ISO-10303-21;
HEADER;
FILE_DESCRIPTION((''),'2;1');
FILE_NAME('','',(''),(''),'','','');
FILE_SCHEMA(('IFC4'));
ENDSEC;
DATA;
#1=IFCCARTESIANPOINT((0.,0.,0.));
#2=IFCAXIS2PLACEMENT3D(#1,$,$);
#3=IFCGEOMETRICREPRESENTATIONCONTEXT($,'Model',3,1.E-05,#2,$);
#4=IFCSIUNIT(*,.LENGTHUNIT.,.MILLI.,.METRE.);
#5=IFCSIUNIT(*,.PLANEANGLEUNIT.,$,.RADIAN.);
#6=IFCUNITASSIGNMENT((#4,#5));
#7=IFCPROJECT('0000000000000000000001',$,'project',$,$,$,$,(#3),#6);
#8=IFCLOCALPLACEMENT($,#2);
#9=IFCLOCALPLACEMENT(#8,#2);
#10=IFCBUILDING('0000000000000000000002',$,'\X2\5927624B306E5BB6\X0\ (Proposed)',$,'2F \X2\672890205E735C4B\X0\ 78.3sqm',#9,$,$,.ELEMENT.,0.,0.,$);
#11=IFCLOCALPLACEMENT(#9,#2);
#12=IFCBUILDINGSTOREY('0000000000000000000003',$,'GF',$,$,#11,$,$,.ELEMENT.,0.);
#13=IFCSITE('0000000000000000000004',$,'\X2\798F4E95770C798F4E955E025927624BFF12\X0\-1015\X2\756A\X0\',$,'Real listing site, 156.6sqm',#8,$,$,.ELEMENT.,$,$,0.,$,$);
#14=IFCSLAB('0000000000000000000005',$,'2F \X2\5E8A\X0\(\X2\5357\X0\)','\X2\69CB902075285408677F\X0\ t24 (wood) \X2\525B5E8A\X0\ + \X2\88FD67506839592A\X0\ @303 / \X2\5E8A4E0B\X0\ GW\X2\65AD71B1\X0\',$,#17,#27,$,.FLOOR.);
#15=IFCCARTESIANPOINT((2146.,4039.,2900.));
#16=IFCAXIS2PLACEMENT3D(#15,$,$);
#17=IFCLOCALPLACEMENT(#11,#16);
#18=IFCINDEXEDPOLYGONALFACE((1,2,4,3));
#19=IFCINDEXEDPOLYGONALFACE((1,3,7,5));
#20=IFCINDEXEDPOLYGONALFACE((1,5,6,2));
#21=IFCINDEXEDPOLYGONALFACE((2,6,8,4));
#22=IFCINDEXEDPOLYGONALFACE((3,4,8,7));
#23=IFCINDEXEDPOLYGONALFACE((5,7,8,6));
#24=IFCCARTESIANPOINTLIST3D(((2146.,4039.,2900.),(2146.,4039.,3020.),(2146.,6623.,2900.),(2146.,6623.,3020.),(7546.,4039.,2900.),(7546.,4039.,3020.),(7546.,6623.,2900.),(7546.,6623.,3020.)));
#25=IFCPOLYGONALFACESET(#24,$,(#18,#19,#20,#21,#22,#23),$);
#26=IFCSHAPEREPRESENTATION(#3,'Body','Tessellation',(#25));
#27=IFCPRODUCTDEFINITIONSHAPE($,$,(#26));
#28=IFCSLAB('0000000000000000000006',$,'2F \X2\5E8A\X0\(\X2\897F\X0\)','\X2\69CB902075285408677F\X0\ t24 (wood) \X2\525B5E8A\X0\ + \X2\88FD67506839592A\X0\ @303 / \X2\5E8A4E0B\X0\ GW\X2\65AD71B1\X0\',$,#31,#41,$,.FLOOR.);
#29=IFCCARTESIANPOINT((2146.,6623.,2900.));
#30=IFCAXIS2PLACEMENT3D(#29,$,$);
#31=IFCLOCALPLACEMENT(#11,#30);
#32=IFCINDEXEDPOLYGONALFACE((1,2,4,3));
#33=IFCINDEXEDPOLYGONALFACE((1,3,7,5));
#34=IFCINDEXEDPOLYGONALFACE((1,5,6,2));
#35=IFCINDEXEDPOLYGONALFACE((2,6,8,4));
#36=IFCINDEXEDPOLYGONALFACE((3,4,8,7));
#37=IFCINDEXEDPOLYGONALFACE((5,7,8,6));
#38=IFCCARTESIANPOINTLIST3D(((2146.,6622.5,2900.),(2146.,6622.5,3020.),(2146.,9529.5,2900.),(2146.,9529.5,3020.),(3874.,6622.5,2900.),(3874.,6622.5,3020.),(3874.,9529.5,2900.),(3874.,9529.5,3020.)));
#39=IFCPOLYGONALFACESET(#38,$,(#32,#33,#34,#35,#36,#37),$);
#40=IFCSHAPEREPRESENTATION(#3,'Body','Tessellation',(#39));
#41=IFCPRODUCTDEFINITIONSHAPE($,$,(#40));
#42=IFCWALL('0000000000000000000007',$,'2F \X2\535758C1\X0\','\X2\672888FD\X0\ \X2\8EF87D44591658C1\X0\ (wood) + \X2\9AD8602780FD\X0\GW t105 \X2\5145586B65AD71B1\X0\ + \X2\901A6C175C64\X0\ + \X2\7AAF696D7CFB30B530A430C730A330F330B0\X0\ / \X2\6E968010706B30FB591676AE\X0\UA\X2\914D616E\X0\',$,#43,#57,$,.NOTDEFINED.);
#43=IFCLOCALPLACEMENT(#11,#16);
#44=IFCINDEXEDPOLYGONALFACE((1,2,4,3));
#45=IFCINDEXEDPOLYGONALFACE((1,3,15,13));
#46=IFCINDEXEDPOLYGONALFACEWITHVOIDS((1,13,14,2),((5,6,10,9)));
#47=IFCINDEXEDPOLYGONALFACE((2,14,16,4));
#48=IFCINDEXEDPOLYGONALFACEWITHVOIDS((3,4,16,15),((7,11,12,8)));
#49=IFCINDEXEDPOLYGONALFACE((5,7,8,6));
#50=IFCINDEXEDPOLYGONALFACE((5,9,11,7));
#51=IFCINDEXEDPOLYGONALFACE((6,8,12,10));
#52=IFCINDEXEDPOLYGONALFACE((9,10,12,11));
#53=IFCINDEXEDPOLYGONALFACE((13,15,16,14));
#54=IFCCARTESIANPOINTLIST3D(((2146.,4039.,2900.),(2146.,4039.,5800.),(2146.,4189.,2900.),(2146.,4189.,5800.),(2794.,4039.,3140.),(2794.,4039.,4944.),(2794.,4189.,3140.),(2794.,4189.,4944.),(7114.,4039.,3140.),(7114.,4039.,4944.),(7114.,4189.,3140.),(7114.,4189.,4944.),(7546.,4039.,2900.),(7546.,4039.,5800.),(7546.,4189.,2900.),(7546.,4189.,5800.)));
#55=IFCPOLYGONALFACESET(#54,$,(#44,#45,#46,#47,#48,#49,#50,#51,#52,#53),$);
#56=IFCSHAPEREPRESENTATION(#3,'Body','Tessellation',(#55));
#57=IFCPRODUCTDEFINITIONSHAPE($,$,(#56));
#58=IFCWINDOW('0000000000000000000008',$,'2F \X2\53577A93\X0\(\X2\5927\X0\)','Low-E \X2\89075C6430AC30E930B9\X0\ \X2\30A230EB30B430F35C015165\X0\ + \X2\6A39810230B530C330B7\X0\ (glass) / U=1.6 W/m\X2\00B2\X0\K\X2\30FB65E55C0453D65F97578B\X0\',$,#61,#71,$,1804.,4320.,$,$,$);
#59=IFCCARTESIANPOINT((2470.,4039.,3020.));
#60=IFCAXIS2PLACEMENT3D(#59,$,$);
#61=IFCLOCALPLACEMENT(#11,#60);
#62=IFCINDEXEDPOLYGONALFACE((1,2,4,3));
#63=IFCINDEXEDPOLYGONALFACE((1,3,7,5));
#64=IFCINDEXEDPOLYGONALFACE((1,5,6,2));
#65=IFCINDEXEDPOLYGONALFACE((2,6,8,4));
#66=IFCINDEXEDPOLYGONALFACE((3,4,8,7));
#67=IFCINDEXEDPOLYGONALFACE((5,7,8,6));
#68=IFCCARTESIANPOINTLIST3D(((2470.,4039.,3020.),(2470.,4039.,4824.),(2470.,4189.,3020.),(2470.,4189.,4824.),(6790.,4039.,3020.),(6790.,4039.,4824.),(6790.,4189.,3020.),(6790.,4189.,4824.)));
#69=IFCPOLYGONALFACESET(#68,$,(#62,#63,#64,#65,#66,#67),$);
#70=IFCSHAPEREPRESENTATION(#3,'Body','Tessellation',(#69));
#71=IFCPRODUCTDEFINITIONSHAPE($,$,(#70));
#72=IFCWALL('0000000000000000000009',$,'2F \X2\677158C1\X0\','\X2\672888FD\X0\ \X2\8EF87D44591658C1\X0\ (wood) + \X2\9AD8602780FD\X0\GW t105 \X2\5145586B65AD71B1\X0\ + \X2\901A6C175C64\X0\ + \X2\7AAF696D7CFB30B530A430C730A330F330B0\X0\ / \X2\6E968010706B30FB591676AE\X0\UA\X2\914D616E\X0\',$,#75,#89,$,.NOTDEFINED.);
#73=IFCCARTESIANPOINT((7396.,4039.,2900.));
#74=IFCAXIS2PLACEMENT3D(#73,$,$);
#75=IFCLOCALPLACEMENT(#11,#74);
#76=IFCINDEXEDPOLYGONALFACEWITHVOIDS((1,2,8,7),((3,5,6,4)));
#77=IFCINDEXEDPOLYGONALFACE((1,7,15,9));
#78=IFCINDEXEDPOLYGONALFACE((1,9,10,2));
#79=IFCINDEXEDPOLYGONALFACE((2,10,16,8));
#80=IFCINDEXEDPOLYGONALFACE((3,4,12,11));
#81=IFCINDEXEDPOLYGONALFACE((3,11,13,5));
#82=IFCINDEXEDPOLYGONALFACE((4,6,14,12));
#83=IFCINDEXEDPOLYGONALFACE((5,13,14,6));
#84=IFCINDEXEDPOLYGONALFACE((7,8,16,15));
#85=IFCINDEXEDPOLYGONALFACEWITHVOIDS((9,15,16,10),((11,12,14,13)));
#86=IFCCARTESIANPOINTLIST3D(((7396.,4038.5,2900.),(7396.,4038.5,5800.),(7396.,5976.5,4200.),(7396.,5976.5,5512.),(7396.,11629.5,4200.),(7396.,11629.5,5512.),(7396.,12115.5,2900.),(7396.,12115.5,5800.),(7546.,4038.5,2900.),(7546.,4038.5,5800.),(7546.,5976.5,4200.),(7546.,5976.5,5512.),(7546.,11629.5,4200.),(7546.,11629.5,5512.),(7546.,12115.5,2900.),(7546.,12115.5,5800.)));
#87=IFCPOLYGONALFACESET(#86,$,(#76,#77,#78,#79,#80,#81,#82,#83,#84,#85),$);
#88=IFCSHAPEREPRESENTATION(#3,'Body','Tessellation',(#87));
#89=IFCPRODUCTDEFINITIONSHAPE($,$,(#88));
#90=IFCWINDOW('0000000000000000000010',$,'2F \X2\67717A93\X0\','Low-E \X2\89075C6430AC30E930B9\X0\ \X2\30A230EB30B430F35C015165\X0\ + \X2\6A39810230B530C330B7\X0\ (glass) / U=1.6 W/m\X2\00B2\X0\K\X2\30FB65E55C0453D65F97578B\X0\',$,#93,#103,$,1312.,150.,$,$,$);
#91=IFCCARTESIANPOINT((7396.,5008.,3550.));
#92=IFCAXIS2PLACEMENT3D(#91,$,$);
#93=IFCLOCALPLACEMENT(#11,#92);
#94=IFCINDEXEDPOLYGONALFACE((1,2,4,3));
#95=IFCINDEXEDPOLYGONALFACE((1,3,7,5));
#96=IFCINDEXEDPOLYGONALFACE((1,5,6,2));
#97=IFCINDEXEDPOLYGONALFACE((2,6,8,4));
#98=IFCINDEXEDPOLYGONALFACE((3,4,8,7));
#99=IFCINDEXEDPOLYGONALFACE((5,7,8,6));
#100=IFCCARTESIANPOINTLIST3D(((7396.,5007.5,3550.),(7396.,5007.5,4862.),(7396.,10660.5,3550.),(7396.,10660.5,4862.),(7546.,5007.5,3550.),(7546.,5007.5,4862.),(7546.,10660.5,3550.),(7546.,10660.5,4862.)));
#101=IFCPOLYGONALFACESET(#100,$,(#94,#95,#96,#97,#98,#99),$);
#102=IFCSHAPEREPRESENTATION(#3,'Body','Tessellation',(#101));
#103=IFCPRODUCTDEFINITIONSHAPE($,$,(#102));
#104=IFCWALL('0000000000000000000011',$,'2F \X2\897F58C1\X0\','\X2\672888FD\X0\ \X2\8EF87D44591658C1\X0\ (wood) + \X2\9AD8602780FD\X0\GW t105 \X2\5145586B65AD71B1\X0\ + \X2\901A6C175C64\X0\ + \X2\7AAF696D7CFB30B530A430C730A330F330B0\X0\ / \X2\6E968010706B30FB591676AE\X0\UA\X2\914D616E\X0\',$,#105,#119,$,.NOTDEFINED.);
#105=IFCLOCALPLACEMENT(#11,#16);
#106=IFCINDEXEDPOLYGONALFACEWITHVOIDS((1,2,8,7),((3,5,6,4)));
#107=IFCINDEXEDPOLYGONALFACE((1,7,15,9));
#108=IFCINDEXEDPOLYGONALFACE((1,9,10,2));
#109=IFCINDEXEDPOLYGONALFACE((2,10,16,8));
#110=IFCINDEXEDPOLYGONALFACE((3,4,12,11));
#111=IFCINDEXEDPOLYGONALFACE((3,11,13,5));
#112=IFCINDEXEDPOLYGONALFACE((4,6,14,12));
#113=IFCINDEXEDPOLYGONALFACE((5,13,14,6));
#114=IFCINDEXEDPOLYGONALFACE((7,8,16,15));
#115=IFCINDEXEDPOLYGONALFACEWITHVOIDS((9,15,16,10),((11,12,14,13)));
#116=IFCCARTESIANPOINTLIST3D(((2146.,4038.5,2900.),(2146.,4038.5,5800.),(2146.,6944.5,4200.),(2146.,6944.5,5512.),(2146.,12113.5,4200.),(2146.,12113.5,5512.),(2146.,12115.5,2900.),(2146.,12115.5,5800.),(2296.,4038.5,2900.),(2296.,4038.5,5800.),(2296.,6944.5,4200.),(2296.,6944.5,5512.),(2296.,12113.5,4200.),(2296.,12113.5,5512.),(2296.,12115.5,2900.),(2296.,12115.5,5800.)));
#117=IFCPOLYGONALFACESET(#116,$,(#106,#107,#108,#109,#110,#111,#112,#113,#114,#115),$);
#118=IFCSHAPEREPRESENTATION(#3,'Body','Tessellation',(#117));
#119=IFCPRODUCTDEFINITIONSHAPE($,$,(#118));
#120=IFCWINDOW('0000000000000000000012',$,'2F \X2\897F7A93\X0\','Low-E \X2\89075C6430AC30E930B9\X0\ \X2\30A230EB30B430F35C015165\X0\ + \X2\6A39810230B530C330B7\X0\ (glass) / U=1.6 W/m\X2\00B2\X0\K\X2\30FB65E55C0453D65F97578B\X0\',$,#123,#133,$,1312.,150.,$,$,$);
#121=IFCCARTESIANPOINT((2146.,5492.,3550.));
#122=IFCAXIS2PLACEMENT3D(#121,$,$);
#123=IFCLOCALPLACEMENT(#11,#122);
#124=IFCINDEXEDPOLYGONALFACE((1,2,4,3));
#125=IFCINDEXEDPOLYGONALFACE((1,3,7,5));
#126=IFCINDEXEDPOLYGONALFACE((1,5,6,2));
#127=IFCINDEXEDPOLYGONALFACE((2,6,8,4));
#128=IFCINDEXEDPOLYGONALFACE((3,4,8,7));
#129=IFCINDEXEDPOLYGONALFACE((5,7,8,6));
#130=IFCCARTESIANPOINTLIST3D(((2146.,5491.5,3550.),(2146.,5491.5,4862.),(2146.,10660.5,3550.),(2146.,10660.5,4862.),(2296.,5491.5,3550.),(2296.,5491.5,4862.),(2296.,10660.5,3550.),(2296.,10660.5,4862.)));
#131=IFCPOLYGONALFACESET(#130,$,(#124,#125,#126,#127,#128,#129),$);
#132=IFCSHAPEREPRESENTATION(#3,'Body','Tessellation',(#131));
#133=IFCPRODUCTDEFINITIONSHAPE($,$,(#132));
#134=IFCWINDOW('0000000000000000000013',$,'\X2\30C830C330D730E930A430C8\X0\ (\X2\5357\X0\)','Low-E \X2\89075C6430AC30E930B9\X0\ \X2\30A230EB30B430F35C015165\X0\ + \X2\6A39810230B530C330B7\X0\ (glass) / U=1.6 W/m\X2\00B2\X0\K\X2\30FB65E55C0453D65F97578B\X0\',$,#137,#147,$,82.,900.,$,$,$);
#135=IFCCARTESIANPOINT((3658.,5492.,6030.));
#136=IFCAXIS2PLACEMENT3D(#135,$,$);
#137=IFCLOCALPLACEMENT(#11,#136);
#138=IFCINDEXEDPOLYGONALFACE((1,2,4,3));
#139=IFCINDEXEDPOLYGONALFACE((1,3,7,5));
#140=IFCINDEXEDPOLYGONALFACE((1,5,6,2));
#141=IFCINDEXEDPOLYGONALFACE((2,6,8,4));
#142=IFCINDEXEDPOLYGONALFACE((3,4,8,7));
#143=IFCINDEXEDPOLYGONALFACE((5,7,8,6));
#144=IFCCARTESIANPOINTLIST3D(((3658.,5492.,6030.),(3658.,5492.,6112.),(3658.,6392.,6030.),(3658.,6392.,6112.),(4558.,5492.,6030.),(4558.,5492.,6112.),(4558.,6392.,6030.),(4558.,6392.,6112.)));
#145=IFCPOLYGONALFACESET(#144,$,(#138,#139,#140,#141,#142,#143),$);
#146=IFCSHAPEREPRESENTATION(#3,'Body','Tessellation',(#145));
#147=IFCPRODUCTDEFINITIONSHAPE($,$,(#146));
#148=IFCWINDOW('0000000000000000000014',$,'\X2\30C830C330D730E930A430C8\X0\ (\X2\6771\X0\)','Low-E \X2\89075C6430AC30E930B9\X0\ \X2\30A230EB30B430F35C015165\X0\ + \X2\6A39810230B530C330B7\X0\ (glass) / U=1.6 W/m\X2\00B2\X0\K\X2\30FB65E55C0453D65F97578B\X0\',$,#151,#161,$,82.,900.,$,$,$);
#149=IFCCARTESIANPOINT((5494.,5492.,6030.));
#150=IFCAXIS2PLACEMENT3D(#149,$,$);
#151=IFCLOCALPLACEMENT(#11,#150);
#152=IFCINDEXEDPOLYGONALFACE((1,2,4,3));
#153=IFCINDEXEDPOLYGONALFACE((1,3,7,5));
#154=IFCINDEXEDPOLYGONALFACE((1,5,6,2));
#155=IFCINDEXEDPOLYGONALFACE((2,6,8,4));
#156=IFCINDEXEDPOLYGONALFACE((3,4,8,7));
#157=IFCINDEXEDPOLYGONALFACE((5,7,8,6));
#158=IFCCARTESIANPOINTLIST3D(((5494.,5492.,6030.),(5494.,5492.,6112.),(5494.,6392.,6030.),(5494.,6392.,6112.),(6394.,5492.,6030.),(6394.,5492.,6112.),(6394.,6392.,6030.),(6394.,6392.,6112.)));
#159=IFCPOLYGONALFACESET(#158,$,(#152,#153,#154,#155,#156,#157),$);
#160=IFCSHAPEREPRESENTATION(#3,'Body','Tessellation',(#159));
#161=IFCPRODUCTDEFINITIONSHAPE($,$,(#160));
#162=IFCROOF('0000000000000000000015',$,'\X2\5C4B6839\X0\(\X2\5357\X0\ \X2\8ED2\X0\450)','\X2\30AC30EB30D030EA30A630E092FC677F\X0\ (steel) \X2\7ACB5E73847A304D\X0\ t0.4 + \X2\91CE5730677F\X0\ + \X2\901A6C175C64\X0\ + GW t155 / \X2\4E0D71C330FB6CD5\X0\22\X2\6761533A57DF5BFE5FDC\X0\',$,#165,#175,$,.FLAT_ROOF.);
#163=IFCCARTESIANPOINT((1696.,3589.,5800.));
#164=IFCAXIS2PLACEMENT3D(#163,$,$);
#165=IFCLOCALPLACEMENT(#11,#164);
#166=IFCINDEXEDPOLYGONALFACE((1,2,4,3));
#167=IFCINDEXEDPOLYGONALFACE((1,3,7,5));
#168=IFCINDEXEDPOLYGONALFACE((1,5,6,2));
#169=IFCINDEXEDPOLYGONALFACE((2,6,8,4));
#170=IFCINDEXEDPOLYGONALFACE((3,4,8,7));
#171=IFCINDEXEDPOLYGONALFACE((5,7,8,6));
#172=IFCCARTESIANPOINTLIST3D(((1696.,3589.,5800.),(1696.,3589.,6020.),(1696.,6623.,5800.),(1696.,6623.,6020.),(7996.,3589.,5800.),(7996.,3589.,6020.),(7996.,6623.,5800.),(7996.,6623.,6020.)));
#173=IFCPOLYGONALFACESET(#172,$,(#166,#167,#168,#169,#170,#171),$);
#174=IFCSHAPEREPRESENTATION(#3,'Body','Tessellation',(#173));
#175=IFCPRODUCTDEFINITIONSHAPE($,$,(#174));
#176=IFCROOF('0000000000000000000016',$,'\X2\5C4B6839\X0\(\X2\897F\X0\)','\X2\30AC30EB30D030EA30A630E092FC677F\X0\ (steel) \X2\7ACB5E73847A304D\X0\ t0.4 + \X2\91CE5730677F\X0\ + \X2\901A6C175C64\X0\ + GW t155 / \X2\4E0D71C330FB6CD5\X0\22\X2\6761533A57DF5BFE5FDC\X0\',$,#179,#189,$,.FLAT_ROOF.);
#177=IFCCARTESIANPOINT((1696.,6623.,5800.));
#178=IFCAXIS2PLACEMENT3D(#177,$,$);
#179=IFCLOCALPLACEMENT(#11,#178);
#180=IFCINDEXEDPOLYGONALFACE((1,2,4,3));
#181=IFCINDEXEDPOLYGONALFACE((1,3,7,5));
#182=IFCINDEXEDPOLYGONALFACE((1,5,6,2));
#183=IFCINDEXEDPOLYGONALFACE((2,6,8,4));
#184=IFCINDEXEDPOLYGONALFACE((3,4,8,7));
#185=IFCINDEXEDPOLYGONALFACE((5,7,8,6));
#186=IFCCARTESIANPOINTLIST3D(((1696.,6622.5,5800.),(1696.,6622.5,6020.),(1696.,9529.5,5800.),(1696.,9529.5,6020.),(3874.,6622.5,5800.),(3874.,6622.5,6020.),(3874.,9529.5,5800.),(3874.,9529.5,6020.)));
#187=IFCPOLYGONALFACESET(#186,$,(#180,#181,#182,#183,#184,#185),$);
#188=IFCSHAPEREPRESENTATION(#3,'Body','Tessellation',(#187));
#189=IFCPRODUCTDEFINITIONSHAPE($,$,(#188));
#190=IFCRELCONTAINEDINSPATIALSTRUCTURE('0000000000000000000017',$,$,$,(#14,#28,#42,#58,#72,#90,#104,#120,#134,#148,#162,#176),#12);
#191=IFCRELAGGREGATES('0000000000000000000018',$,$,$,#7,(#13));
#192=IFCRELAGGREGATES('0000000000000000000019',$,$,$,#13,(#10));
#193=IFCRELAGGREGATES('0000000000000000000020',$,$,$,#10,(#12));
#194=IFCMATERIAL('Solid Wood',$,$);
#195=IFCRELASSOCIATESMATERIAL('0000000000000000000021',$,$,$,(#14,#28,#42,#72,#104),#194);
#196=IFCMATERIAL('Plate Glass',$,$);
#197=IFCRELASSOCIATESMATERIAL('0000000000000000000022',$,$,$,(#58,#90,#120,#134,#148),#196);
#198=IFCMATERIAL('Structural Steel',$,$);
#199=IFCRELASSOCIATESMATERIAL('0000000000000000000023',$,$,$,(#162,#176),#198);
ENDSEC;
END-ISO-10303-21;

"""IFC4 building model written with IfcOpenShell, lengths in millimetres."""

from ifc_helpers import new_model, si_unit, frame, frame_2d, origin, place, context, project, spatial, rectangle, extrude, material, element, fill, save


model = new_model("IFC4")

# Units and contexts
model_context = context("Model", 3, precision=1e-05, world=origin())
ifc_project = project(units=[si_unit("LENGTHUNIT", "METRE", prefix="MILLI"), si_unit("PLANEANGLEUNIT", "RADIAN")], contexts=[model_context])

# Site, building, storey
site_placement = place(None, origin())
site = spatial("IfcSite", under=ifc_project, at=site_placement, Name="福井県福井市大手２-1015番", ObjectType="Real listing site, 156.6sqm", CompositionType="ELEMENT", RefElevation=0.0)
building_placement = place(site_placement, origin())
building = spatial("IfcBuilding", under=site, at=building_placement, Name="大手の家 (Proposed)", ObjectType="2F 木造平屋 78.3sqm", CompositionType="ELEMENT", ElevationOfRefHeight=0.0, ElevationOfTerrain=0.0)
storey_placement = place(building_placement, origin())
storey = spatial("IfcBuildingStorey", under=building, at=storey_placement, Name="GF", CompositionType="ELEMENT", Elevation=0.0)

# Slabs
ifc_material_1 = material(Name="Solid Wood")
slab_1_placement = place(storey_placement, frame((2146.0, 4039.0, 2900.0)))
element("IfcSlab", 1, at=slab_1_placement, inside=storey, material=ifc_material_1, Name="2F 床(南)", Description="構造用合板 t24 (wood) 剛床 + 製材根太 @303 / 床下 GW断熱", PredefinedType="FLOOR", context=model_context, shape_type="SweptSolid", body=[
    extrude(rectangle(XDim=5400.0, YDim=2584.0, at=frame_2d((2700.0, 1292.0))), frame((2146.0, 4039.0, 2900.0)), (0.0, 0.0, 1.0), 120.0),
])
slab_2_placement = place(storey_placement, frame((2146.0, 6623.0, 2900.0)))
element("IfcSlab", 2, at=slab_2_placement, inside=storey, material=ifc_material_1, Name="2F 床(西)", Description="構造用合板 t24 (wood) 剛床 + 製材根太 @303 / 床下 GW断熱", PredefinedType="FLOOR", context=model_context, shape_type="SweptSolid", body=[
    extrude(rectangle(XDim=1728.0, YDim=2907.0, at=frame_2d((864.0, 1453.0))), frame((2146.0, 6623.0, 2900.0)), (0.0, 0.0, 1.0), 120.0),
])

# Walls, openings, windows
wall_1_placement = place(storey_placement, frame((2146.0, 4039.0, 2900.0)))
wall_1 = element("IfcWall", 3, at=wall_1_placement, inside=storey, material=ifc_material_1, Name="2F 南壁", Description="木製 軸組外壁 (wood) + 高性能GW t105 充填断熱 + 通気層 + 窯業系サイディング / 準耐火・外皮UA配慮", PredefinedType="NOTDEFINED", context=model_context, shape_type="SweptSolid", body=[
    extrude(rectangle(XDim=5400.0, YDim=150.0, at=frame_2d((2700.0, 75.0))), frame((2146.0, 4039.0, 2900.0)), (0.0, 0.0, 1.0), 2900.0),
])
opening_1_placement = place(storey_placement, frame((2470.0, 4039.0, 3020.0)))
opening_1 = element("IfcOpeningElement", 4, at=opening_1_placement, cuts=wall_1, PredefinedType="NOTDEFINED", context=model_context, shape_type="SweptSolid", body=[
    extrude(rectangle(XDim=4320.0, YDim=150.0, at=frame_2d((2160.0, 75.0))), frame((2470.0, 4039.0, 3020.0)), (0.0, 0.0, 1.0), 1804.0),
])
ifc_material_2 = material(Name="Plate Glass")
window_1_placement = place(storey_placement, frame((2470.0, 4039.0, 3020.0)))
window_1 = element("IfcWindow", 5, at=window_1_placement, inside=storey, material=ifc_material_2, Name="2F 南窓(大)", Description="Low-E 複層ガラス アルゴン封入 + 樹脂サッシ (glass) / U=1.6 W/m²K・日射取得型", OverallHeight=1804.0, OverallWidth=4320.0, context=model_context, shape_type="SweptSolid", body=[
    extrude(rectangle(XDim=4320.0, YDim=150.0, at=frame_2d((2160.0, 75.0))), frame((2470.0, 4039.0, 3020.0)), (0.0, 0.0, 1.0), 1804.0),
])
fill(opening_1, window_1)
wall_2_placement = place(storey_placement, frame((7396.0, 4039.0, 2900.0)))
wall_2 = element("IfcWall", 6, at=wall_2_placement, inside=storey, material=ifc_material_1, Name="2F 東壁", Description="木製 軸組外壁 (wood) + 高性能GW t105 充填断熱 + 通気層 + 窯業系サイディング / 準耐火・外皮UA配慮", PredefinedType="NOTDEFINED", context=model_context, shape_type="SweptSolid", body=[
    extrude(rectangle(XDim=150.0, YDim=8077.0, at=frame_2d((75.0, 4038.0))), frame((7396.0, 4039.0, 2900.0)), (0.0, 0.0, 1.0), 2900.0),
])
opening_2_placement = place(storey_placement, frame((7396.0, 5008.0, 3550.0)))
opening_2 = element("IfcOpeningElement", 7, at=opening_2_placement, cuts=wall_2, PredefinedType="NOTDEFINED", context=model_context, shape_type="SweptSolid", body=[
    extrude(rectangle(XDim=150.0, YDim=5653.0, at=frame_2d((75.0, 2826.0))), frame((7396.0, 5008.0, 3550.0)), (0.0, 0.0, 1.0), 1312.0),
])
window_2_placement = place(storey_placement, frame((7396.0, 5008.0, 3550.0)))
window_2 = element("IfcWindow", 8, at=window_2_placement, inside=storey, material=ifc_material_2, Name="2F 東窓", Description="Low-E 複層ガラス アルゴン封入 + 樹脂サッシ (glass) / U=1.6 W/m²K・日射取得型", OverallHeight=1312.0, OverallWidth=150.0, context=model_context, shape_type="SweptSolid", body=[
    extrude(rectangle(XDim=150.0, YDim=5653.0, at=frame_2d((75.0, 2826.0))), frame((7396.0, 5008.0, 3550.0)), (0.0, 0.0, 1.0), 1312.0),
])
fill(opening_2, window_2)
wall_3_placement = place(storey_placement, frame((2146.0, 4039.0, 2900.0)))
wall_3 = element("IfcWall", 9, at=wall_3_placement, inside=storey, material=ifc_material_1, Name="2F 西壁", Description="木製 軸組外壁 (wood) + 高性能GW t105 充填断熱 + 通気層 + 窯業系サイディング / 準耐火・外皮UA配慮", PredefinedType="NOTDEFINED", context=model_context, shape_type="SweptSolid", body=[
    extrude(rectangle(XDim=150.0, YDim=8077.0, at=frame_2d((75.0, 4038.0))), frame((2146.0, 4039.0, 2900.0)), (0.0, 0.0, 1.0), 2900.0),
])
opening_3_placement = place(storey_placement, frame((2146.0, 5492.0, 3550.0)))
opening_3 = element("IfcOpeningElement", 10, at=opening_3_placement, cuts=wall_3, PredefinedType="NOTDEFINED", context=model_context, shape_type="SweptSolid", body=[
    extrude(rectangle(XDim=150.0, YDim=5169.0, at=frame_2d((75.0, 2584.0))), frame((2146.0, 5492.0, 3550.0)), (0.0, 0.0, 1.0), 1312.0),
])
window_3_placement = place(storey_placement, frame((2146.0, 5492.0, 3550.0)))
window_3 = element("IfcWindow", 11, at=window_3_placement, inside=storey, material=ifc_material_2, Name="2F 西窓", Description="Low-E 複層ガラス アルゴン封入 + 樹脂サッシ (glass) / U=1.6 W/m²K・日射取得型", OverallHeight=1312.0, OverallWidth=150.0, context=model_context, shape_type="SweptSolid", body=[
    extrude(rectangle(XDim=150.0, YDim=5169.0, at=frame_2d((75.0, 2584.0))), frame((2146.0, 5492.0, 3550.0)), (0.0, 0.0, 1.0), 1312.0),
])
fill(opening_3, window_3)

# Windows
window_4_placement = place(storey_placement, frame((3658.0, 5492.0, 6030.0)))
element("IfcWindow", 12, at=window_4_placement, inside=storey, material=ifc_material_2, Name="トップライト (南)", Description="Low-E 複層ガラス アルゴン封入 + 樹脂サッシ (glass) / U=1.6 W/m²K・日射取得型", OverallHeight=82.0, OverallWidth=900.0, context=model_context, shape_type="SweptSolid", body=[
    extrude(rectangle(XDim=900.0, YDim=900.0, at=frame_2d((450.0, 450.0))), frame((3658.0, 5492.0, 6030.0)), (0.0, 0.0, 1.0), 82.0),
])
window_5_placement = place(storey_placement, frame((5494.0, 5492.0, 6030.0)))
element("IfcWindow", 13, at=window_5_placement, inside=storey, material=ifc_material_2, Name="トップライト (東)", Description="Low-E 複層ガラス アルゴン封入 + 樹脂サッシ (glass) / U=1.6 W/m²K・日射取得型", OverallHeight=82.0, OverallWidth=900.0, context=model_context, shape_type="SweptSolid", body=[
    extrude(rectangle(XDim=900.0, YDim=900.0, at=frame_2d((450.0, 450.0))), frame((5494.0, 5492.0, 6030.0)), (0.0, 0.0, 1.0), 82.0),
])

# Roofs
ifc_material_3 = material(Name="Structural Steel")
roof_1_placement = place(storey_placement, frame((1696.0, 3589.0, 5800.0)))
element("IfcRoof", 14, at=roof_1_placement, inside=storey, material=ifc_material_3, Name="屋根(南 軒450)", Description="ガルバリウム鋼板 (steel) 立平葺き t0.4 + 野地板 + 通気層 + GW t155 / 不燃・法22条区域対応", PredefinedType="FLAT_ROOF", context=model_context, shape_type="SweptSolid", body=[
    extrude(rectangle(XDim=6300.0, YDim=3034.0, at=frame_2d((3150.0, 1517.0))), frame((1696.0, 3589.0, 5800.0)), (0.0, 0.0, 1.0), 220.0),
])
roof_2_placement = place(storey_placement, frame((1696.0, 6623.0, 5800.0)))
element("IfcRoof", 15, at=roof_2_placement, inside=storey, material=ifc_material_3, Name="屋根(西)", Description="ガルバリウム鋼板 (steel) 立平葺き t0.4 + 野地板 + 通気層 + GW t155 / 不燃・法22条区域対応", PredefinedType="FLAT_ROOF", context=model_context, shape_type="SweptSolid", body=[
    extrude(rectangle(XDim=2178.0, YDim=2907.0, at=frame_2d((1089.0, 1453.0))), frame((1696.0, 6623.0, 5800.0)), (0.0, 0.0, 1.0), 220.0),
])

save(model, "model.ifc")
